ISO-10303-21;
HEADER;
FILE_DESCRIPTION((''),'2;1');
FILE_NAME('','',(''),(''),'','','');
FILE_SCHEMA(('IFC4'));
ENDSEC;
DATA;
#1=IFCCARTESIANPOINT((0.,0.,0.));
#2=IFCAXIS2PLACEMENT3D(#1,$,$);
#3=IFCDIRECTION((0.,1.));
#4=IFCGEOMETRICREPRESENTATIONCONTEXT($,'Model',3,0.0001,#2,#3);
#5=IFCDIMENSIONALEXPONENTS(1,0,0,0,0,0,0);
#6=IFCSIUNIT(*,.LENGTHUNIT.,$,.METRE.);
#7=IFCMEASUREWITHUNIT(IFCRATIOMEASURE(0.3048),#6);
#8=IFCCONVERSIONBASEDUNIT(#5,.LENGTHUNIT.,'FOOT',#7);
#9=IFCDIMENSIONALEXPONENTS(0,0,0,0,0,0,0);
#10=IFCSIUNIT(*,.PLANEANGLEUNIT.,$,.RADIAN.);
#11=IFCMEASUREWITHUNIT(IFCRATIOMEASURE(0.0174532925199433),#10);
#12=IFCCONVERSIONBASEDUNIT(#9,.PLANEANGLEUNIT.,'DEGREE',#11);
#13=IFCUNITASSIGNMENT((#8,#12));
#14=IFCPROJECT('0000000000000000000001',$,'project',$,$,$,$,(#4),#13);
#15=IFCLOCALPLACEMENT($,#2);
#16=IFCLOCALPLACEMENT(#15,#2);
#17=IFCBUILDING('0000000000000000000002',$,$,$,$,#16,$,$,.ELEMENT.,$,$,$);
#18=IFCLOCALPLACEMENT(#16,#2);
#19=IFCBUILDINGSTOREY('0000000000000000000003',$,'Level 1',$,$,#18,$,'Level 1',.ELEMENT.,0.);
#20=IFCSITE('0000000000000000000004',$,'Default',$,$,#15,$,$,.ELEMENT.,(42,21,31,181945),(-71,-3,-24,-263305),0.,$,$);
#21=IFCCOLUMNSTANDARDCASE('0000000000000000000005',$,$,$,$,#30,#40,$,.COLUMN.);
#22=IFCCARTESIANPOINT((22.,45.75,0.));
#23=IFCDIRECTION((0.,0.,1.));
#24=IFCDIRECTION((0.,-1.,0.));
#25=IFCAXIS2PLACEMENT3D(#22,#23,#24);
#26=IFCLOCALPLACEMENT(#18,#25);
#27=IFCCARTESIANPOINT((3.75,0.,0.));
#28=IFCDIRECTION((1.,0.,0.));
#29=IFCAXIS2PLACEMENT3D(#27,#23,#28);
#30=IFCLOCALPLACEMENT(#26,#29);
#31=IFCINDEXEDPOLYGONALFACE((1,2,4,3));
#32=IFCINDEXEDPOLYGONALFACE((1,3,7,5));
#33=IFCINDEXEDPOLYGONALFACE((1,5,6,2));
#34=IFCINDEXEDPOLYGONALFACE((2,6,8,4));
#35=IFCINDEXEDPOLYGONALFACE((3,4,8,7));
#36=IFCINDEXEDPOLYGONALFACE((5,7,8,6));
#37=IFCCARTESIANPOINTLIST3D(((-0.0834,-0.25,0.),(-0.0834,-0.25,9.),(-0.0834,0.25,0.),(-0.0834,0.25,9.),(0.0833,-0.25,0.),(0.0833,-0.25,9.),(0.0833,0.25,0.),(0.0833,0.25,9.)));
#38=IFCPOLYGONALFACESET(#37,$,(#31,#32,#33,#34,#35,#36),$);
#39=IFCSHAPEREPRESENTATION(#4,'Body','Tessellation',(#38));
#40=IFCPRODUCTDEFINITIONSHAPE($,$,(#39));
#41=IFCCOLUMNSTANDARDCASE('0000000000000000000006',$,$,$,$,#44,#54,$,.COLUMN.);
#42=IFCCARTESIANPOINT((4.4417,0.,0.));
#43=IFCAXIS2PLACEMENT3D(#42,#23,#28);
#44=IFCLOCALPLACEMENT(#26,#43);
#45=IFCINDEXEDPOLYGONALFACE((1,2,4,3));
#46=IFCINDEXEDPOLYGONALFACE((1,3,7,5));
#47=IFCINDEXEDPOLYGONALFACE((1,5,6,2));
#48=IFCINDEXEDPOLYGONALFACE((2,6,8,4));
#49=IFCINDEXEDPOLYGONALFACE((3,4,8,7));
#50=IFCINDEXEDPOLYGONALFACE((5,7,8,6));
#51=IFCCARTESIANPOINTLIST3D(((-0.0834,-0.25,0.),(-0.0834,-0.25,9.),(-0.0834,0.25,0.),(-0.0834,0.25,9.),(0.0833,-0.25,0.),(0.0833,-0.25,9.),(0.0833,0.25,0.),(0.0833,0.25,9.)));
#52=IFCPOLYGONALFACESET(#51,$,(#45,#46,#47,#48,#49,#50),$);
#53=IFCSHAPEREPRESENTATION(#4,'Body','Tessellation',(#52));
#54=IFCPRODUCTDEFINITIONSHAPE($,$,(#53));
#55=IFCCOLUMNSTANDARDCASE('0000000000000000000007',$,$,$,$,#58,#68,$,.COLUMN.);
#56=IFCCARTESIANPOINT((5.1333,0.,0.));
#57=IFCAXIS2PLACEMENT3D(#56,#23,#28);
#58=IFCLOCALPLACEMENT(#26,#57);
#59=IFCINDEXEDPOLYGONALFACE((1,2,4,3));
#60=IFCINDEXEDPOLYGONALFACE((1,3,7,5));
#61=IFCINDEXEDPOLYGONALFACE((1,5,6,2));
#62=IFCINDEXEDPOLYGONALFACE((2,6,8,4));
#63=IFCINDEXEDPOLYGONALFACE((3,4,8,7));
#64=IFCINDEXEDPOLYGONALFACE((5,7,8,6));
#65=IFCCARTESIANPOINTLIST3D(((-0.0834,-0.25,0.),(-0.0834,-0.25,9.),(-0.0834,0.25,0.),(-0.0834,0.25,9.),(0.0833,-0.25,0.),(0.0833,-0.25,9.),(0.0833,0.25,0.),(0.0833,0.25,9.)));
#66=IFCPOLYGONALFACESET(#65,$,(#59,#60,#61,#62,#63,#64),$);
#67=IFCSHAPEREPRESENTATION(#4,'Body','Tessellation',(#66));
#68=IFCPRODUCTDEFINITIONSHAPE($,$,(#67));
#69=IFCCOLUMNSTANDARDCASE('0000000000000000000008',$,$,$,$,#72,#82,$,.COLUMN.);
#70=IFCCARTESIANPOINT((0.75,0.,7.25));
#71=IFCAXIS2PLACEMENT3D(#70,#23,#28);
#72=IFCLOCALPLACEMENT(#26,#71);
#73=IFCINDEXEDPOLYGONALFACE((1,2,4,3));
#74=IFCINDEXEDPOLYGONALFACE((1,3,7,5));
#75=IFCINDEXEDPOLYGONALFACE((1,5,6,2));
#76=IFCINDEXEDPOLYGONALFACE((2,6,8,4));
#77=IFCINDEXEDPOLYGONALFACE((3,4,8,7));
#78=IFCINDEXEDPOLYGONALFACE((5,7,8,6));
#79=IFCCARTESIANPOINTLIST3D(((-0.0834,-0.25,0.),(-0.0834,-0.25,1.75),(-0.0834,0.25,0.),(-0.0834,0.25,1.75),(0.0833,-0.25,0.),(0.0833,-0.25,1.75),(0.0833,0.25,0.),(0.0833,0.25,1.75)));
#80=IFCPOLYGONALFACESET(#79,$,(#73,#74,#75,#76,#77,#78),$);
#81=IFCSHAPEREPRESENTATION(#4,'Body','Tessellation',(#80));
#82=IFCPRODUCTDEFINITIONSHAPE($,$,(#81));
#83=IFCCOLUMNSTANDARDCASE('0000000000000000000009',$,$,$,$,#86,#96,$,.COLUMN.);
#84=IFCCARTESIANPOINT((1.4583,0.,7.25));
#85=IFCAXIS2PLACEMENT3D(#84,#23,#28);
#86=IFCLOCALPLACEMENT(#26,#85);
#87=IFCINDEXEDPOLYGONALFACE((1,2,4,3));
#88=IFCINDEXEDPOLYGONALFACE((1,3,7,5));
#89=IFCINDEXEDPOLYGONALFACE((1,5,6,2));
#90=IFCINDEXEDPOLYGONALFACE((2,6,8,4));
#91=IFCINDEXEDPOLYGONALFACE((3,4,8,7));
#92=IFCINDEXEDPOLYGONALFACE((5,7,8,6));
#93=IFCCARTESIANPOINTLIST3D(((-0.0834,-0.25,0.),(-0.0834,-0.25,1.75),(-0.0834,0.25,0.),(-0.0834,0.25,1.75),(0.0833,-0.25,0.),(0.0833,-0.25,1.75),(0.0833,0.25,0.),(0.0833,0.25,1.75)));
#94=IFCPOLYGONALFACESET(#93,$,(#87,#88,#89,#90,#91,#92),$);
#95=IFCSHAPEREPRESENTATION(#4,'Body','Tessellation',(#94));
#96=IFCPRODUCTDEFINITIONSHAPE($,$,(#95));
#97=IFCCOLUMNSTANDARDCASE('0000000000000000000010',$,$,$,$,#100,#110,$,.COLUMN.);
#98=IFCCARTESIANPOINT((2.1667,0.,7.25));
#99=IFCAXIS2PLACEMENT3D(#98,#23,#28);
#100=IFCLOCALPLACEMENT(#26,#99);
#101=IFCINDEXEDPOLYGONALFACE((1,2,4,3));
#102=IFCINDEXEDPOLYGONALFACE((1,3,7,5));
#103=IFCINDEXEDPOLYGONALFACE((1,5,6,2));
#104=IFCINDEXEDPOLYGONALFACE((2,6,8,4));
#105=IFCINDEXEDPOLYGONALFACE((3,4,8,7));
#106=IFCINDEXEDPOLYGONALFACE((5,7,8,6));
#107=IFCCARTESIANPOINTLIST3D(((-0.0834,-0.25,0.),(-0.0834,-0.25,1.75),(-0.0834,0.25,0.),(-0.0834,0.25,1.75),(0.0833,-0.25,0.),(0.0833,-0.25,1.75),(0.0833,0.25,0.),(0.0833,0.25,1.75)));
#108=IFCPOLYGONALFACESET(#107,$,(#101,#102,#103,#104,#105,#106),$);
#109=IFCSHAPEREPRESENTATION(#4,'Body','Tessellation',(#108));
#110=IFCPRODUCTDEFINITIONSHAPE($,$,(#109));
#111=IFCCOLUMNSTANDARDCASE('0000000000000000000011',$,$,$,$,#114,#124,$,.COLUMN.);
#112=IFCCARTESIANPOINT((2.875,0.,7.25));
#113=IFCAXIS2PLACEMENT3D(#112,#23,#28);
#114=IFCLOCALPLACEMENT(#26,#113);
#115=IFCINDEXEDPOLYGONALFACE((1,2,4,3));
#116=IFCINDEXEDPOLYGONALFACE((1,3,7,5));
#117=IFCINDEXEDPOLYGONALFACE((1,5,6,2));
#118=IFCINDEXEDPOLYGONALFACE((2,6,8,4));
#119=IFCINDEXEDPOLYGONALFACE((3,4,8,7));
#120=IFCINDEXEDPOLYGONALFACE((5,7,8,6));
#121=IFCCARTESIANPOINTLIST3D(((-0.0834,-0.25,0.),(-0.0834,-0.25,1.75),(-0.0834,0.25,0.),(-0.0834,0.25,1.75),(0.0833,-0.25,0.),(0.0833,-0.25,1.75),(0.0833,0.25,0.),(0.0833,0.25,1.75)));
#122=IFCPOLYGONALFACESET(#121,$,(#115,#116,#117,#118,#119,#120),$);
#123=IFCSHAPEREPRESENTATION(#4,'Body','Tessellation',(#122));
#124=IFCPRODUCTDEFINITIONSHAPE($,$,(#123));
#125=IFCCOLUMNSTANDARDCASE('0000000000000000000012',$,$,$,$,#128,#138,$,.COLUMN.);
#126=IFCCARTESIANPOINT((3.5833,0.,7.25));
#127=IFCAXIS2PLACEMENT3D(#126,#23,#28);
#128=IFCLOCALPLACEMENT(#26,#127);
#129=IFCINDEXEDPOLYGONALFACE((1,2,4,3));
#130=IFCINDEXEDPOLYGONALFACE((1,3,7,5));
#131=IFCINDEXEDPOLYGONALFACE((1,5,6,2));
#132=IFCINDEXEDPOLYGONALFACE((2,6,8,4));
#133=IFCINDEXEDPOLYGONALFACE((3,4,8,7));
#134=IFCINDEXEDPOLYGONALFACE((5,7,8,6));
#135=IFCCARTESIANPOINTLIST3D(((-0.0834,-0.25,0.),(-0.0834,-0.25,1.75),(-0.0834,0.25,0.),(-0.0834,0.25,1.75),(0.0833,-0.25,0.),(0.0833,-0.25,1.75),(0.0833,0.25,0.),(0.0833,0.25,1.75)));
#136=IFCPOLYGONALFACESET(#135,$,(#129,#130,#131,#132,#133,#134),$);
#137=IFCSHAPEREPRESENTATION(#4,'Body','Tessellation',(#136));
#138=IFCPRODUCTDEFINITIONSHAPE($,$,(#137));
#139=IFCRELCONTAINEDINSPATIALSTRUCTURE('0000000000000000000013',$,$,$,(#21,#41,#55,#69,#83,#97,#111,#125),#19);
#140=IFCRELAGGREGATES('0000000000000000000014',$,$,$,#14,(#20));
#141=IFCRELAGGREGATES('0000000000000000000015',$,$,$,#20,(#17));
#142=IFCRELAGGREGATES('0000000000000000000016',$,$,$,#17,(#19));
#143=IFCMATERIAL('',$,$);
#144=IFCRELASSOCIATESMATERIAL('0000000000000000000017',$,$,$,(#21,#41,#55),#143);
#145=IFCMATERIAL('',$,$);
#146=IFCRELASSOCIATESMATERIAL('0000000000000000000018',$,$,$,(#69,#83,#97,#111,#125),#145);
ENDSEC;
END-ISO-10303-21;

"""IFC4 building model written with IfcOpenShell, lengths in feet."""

from ifc_helpers import new_model, entity, si_unit, converted_unit, direction, frame, origin, place, context, project, spatial, rectangle, extrude, material, element, save


model = new_model("IFC4")

# Units and contexts
model_context = context("Model", 3, precision=0.0001, world=origin(), true_north=direction((0.0, 1.0)))
ifc_project = project(units=[converted_unit("LENGTHUNIT", "FOOT", entity("IfcRatioMeasure", 0.3048), si_unit("LENGTHUNIT", "METRE"), dimensions=[1, 0, 0, 0, 0, 0, 0]), converted_unit("PLANEANGLEUNIT", "DEGREE", entity("IfcRatioMeasure", 0.0174532925199433), si_unit("PLANEANGLEUNIT", "RADIAN"), dimensions=[0, 0, 0, 0, 0, 0, 0])], contexts=[model_context])

# Site, building, storey
site_placement = place(None, origin())
site = spatial("IfcSite", under=ifc_project, at=site_placement, Name="Default", CompositionType="ELEMENT", RefLatitude=(42, 21, 31, 181945), RefLongitude=(-71, -3, -24, -263305), RefElevation=0.0)
building_placement = place(site_placement, origin())
building = spatial("IfcBuilding", under=site, at=building_placement, CompositionType="ELEMENT")
storey_placement = place(building_placement, origin())
storey = spatial("IfcBuildingStorey", under=building, at=storey_placement, Name="Level 1", LongName="Level 1", CompositionType="ELEMENT", Elevation=0.0)

# Columns
ifc_material_1 = material(Name="")
ifc_material_2 = material(Name="")
placement_1 = place(storey_placement, frame((22.0, 45.75, 0.0), z_axis=(0.0, 0.0, 1.0), x_axis=(0.0, -1.0, 0.0)))
for number, where, z_axis, x_axis in (
    (1, (3.75, 0.0, 0.0), (0.0, 0.0, 1.0), (1.0, 0.0, 0.0)),
    (2, (4.4417, 0.0, 0.0), (0.0, 0.0, 1.0), (1.0, 0.0, 0.0)),
    (3, (5.1333, 0.0, 0.0), (0.0, 0.0, 1.0), (1.0, 0.0, 0.0)),
):
    element("IfcColumnStandardCase", number, at=place(placement_1, frame(where, z_axis=z_axis, x_axis=x_axis)), inside=storey, material=ifc_material_1, PredefinedType="COLUMN", context=model_context, shape_type="SweptSolid", body=[
        extrude(rectangle(XDim=0.1667, YDim=0.5), origin(), (0.0, 0.0, 1.0), 9.0),
    ])
for number, where, z_axis, x_axis in (
    (4, (0.75, 0.0, 7.25), (0.0, 0.0, 1.0), (1.0, 0.0, 0.0)),
    (5, (1.4583, 0.0, 7.25), (0.0, 0.0, 1.0), (1.0, 0.0, 0.0)),
    (6, (2.1667, 0.0, 7.25), (0.0, 0.0, 1.0), (1.0, 0.0, 0.0)),
    (7, (2.875, 0.0, 7.25), (0.0, 0.0, 1.0), (1.0, 0.0, 0.0)),
    (8, (3.5833, 0.0, 7.25), (0.0, 0.0, 1.0), (1.0, 0.0, 0.0)),
):
    element("IfcColumnStandardCase", number, at=place(placement_1, frame(where, z_axis=z_axis, x_axis=x_axis)), inside=storey, material=ifc_material_2, PredefinedType="COLUMN", context=model_context, shape_type="SweptSolid", body=[
        extrude(rectangle(XDim=0.1667, YDim=0.5), origin(), (0.0, 0.0, 1.0), 1.75),
    ])

save(model, "model.ifc")
